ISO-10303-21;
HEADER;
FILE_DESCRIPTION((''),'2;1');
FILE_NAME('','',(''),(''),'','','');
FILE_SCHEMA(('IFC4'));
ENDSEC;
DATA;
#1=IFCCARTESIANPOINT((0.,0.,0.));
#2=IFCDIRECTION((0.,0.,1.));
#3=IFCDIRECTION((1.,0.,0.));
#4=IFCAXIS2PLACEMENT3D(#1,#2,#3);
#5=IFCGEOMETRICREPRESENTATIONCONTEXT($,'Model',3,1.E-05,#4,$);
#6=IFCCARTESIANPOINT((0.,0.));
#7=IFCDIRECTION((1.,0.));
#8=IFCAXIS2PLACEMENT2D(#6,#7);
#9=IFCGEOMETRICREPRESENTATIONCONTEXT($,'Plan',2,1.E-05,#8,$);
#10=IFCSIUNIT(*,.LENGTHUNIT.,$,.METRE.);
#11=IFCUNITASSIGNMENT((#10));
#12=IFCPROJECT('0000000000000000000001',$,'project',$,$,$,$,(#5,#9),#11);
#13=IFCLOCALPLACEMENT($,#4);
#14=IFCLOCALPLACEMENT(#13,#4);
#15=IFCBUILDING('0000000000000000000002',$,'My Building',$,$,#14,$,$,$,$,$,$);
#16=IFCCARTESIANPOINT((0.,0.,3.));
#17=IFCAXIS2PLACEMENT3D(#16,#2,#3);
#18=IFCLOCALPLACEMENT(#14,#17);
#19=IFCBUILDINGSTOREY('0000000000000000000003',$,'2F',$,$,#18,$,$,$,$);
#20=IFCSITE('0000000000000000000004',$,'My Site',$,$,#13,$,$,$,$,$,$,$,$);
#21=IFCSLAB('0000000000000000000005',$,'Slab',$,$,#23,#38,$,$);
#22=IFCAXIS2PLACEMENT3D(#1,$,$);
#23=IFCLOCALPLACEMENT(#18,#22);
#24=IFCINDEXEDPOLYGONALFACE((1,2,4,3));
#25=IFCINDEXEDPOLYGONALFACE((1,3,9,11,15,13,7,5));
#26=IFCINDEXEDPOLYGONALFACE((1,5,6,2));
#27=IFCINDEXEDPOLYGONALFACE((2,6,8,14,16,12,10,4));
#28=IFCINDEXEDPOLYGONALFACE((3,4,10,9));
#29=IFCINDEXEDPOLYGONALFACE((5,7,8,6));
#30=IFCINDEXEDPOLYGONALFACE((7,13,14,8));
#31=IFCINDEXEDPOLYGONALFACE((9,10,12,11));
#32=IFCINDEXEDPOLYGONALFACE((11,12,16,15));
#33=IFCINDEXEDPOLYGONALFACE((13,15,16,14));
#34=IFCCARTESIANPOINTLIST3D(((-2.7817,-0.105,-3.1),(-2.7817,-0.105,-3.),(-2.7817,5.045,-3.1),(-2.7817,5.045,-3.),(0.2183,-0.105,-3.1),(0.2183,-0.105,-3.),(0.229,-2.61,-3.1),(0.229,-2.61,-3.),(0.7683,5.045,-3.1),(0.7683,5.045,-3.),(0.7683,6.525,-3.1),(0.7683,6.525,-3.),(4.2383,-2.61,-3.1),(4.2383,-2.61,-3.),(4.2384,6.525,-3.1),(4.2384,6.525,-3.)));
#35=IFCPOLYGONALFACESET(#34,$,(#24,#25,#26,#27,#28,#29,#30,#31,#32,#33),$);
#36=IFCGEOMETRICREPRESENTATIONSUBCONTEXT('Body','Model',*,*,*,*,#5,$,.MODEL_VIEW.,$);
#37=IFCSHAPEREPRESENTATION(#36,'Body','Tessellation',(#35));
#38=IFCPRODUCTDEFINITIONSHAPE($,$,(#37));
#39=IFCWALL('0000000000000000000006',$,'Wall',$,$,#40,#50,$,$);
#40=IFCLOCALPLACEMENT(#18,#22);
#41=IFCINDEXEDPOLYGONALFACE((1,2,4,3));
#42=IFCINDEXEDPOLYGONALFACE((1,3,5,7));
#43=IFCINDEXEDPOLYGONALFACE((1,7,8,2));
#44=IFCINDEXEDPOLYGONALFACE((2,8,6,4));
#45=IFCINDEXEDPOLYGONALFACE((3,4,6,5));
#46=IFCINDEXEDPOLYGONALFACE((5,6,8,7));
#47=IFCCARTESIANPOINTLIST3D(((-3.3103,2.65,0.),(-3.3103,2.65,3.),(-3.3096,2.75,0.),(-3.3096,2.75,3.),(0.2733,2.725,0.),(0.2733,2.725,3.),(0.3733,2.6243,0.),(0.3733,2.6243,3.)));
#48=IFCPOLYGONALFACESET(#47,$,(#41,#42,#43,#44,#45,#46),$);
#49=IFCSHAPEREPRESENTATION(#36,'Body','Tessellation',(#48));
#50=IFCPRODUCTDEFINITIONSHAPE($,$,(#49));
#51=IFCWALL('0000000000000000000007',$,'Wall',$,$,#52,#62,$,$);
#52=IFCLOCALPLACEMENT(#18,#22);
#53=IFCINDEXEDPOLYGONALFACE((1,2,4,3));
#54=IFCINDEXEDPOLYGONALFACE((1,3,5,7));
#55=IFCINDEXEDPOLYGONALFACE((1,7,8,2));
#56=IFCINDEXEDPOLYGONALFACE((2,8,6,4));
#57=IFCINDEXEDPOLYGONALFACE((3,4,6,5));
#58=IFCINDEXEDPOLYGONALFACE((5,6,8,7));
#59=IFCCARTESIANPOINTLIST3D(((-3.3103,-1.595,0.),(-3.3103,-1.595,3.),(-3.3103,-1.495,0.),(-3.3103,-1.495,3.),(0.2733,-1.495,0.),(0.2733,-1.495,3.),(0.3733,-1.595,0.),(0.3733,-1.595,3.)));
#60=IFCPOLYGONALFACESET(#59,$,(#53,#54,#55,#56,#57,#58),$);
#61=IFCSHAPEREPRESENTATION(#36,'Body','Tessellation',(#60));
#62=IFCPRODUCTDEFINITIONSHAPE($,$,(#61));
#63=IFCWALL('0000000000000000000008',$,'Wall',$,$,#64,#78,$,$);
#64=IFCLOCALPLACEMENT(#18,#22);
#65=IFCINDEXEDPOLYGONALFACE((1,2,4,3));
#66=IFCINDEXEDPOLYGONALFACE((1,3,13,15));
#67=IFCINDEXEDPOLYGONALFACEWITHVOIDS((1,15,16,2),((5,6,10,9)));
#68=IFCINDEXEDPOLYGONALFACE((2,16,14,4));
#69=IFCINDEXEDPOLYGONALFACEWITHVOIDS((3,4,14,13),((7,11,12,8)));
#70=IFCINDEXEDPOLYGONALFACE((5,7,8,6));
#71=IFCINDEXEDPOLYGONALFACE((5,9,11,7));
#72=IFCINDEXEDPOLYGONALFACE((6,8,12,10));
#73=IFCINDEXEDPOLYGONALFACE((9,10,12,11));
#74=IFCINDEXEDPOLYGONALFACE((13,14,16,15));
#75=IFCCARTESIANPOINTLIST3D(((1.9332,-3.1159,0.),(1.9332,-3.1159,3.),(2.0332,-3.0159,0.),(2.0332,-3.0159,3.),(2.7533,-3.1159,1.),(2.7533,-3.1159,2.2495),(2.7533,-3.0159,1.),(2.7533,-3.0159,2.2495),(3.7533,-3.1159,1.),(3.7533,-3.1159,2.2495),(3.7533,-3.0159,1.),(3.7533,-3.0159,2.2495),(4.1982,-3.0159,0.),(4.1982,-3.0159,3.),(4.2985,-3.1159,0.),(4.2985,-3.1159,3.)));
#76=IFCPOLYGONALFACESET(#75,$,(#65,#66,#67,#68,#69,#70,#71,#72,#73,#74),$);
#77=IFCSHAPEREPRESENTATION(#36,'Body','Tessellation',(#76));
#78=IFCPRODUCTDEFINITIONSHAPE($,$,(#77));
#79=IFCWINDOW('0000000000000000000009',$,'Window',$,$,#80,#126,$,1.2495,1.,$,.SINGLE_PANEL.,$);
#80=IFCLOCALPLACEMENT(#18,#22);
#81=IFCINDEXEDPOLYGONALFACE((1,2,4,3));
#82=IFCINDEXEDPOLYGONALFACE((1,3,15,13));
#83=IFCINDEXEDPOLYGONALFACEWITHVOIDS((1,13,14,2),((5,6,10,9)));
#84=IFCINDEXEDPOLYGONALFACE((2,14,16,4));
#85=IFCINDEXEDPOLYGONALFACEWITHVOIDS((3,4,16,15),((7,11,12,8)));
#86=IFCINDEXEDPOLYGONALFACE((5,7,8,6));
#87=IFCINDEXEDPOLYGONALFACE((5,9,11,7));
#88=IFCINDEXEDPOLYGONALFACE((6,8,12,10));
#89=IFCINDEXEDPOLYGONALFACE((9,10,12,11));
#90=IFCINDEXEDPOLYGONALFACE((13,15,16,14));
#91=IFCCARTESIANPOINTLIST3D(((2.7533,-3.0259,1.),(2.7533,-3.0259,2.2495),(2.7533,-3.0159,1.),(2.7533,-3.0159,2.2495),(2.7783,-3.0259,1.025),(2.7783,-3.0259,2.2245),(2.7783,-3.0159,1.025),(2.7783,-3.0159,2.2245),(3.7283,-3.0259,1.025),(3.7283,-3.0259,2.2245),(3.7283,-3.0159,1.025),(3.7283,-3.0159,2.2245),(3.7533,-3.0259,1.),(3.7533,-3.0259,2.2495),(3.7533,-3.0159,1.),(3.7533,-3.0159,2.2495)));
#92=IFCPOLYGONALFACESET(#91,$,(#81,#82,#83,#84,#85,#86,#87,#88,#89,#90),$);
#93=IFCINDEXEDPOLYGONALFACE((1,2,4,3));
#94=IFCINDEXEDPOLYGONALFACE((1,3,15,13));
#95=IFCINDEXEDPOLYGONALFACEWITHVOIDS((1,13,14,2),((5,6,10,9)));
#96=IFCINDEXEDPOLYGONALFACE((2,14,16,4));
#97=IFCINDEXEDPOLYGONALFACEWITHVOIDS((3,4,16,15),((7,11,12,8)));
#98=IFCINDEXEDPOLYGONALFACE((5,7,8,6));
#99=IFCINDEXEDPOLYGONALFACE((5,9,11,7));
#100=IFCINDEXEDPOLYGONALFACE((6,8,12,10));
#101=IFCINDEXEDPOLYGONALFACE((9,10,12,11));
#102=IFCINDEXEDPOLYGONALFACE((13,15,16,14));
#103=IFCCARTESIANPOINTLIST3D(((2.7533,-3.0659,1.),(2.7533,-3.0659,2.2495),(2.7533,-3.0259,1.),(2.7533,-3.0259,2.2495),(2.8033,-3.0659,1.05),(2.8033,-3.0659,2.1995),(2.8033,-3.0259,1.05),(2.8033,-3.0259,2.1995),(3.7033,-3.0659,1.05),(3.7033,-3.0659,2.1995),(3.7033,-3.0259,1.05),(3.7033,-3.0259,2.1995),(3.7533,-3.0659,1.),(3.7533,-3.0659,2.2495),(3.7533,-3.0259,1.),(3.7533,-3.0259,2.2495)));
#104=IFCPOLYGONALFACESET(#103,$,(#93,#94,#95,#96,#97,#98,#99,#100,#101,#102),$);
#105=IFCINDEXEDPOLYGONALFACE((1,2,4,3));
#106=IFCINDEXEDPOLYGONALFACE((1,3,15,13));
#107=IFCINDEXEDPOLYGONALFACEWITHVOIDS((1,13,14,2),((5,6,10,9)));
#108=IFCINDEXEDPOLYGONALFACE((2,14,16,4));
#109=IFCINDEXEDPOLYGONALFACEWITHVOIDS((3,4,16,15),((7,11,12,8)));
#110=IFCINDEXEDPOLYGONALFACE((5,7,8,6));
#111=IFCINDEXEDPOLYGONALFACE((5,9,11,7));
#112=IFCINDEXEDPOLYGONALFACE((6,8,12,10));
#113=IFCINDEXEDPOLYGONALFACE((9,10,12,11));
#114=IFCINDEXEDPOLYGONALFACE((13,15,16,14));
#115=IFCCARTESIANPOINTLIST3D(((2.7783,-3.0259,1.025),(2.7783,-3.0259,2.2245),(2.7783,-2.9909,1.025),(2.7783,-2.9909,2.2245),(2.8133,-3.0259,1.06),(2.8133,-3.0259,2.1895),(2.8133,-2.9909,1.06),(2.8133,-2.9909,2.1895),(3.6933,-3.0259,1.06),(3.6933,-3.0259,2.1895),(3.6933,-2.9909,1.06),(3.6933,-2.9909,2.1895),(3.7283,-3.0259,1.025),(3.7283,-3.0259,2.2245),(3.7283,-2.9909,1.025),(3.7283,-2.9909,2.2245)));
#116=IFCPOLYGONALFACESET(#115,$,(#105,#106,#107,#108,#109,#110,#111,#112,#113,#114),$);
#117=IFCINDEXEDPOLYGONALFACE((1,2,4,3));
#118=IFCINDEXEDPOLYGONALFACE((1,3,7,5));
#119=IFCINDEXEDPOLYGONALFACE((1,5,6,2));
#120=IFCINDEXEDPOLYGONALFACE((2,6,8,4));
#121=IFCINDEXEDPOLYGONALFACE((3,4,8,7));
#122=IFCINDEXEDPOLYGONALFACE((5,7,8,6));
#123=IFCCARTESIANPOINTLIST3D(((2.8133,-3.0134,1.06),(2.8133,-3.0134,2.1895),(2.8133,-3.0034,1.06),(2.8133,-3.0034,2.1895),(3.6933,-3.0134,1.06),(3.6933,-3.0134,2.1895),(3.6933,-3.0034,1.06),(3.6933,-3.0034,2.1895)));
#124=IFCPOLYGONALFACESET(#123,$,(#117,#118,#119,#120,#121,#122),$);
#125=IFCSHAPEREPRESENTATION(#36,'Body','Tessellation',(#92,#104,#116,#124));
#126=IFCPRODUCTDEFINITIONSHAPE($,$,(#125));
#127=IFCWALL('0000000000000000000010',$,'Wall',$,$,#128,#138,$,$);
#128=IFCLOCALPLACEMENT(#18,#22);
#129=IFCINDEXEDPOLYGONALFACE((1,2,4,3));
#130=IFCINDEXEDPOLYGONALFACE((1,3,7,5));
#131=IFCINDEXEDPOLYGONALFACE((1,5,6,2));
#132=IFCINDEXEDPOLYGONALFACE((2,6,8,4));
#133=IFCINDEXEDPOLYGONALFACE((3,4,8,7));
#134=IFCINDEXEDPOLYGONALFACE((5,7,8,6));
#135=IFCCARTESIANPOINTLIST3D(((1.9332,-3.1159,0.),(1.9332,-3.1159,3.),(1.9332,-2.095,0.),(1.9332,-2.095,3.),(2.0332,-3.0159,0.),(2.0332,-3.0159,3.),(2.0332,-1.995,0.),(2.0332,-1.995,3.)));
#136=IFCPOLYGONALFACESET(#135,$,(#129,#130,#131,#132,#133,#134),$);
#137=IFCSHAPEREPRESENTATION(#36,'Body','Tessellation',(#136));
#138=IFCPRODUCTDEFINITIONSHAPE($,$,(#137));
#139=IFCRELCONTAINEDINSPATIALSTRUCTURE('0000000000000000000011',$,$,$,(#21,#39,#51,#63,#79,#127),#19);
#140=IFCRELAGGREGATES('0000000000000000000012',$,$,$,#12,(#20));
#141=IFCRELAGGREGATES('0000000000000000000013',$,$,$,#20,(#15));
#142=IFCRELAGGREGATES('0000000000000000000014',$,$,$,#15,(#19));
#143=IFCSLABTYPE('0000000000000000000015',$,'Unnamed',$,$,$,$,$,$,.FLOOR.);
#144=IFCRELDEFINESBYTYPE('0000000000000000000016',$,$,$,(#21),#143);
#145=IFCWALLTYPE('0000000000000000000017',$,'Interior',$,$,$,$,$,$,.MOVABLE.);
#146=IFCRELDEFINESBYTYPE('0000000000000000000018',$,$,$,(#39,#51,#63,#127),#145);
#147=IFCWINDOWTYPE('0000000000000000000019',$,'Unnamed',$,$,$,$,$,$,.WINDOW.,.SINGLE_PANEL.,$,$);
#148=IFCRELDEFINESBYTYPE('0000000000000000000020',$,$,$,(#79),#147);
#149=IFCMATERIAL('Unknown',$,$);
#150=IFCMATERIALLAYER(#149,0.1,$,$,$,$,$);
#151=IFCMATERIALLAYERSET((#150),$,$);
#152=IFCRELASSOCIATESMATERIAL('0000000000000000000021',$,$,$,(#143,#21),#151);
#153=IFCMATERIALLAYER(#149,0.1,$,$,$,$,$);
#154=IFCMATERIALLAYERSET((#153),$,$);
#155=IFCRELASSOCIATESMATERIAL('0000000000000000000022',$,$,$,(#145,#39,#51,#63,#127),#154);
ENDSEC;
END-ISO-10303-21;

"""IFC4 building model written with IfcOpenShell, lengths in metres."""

from ifc_helpers import new_model, entity, si_unit, frame, origin_with_axes, origin_2d_with_axis, place, context, subcontext, project, spatial, line, indexed_curve, outline, extrude, shape, source, transform, mapped, material, layer, layer_set, layer_usage, type_object, type_shapes, element, fill, save


model = new_model("IFC4")

# Units and contexts
model_context = context("Model", 3, precision=1e-05, world=origin_with_axes())
plan_context = context("Plan", 2, precision=1e-05, world=origin_2d_with_axis())
body_context_1 = subcontext(model_context, "Body", "Model", "MODEL_VIEW")
body_context_2 = subcontext(plan_context, "Body", "Plan", "PLAN_VIEW")
ifc_project = project(units=[si_unit("LENGTHUNIT", "METRE")], contexts=[model_context, plan_context])

# Site, building, storey
site_placement = place(None, origin_with_axes())
site = spatial("IfcSite", under=ifc_project, at=site_placement, Name="My Site")
building_placement = place(site_placement, origin_with_axes())
building = spatial("IfcBuilding", under=site, at=building_placement, Name="My Building")
storey_placement = place(building_placement, frame((0.0, 0.0, 3.0), z_axis=(0.0, 0.0, 1.0), x_axis=(1.0, 0.0, 0.0)))
storey = spatial("IfcBuildingStorey", under=building, at=storey_placement, Name="2F")

# Slab
ifc_material = material(Name="Unknown")
ifc_layer_1 = layer(ifc_material, 0.1)
ifc_layer_set_1 = layer_set([ifc_layer_1])
ifc_layer_usage_1 = layer_usage(ifc_layer_set_1, "AXIS3", "POSITIVE", -0.1)
slab_type = type_object("IfcSlabType", Name="Unnamed", PredefinedType="FLOOR", material=ifc_layer_set_1)
slab_placement = place(storey_placement, frame((4.2383, -2.61, -3.0), z_axis=(0.0, 0.0, 1.0), x_axis=(1.0, 0.0, 0.0)))
element("IfcSlab", 1, at=slab_placement, inside=storey, type_object=slab_type, material=ifc_layer_usage_1, Name="Slab", context=body_context_1, shape_type="SweptSolid", body=[
    extrude(outline(indexed_curve([(0.0, 0.0), (0.0, 9.135), (-3.47, 9.135), (-3.47, 7.655), (-7.02, 7.655), (-7.02, 2.505), (-4.02, 2.505), (-4.0094, 0.0), (0.0, 0.0)])), frame((0.0, 0.0, -0.1), z_axis=(0.0, 0.0, 1.0), x_axis=(1.0, 0.0, 0.0)), (0.0, 0.0, 1.0), 0.1),
])

# Walls
ifc_layer_2 = layer(ifc_material, 0.1)
ifc_layer_set_2 = layer_set([ifc_layer_2])
ifc_layer_usage_2 = layer_usage(ifc_layer_set_2, "AXIS2", "POSITIVE", 0.0)
wall_type = type_object("IfcWallType", Name="Interior", PredefinedType="MOVABLE", material=ifc_layer_set_2)
wall_1_placement = place(storey_placement, frame((-3.3103, 2.65, 0.0), z_axis=(0.0, 0.0, 1.0), x_axis=(0.999976, -0.006981, 0.0)))
element("IfcWall", 2, at=wall_1_placement, inside=storey, type_object=wall_type, material=ifc_layer_usage_2, Name="Wall", context=body_context_1, shape_type="SweptSolid", body=[
    extrude(outline(indexed_curve([(0.0, 0.0), (0.0, 0.1), (3.583, 0.1), (3.6837, 0.0)], segments=[line(1, 2, 3, 4, 1)])), origin_with_axes(), (0.0, 0.0, 1.0), 3.0),
])
ifc_layer_usage_3 = layer_usage(ifc_layer_set_2, "AXIS2", "POSITIVE", 0.0)
wall_2_placement = place(storey_placement, frame((-3.3103, -1.595, 0.0), z_axis=(0.0, 0.0, 1.0), x_axis=(1.0, 0.0, 0.0)))
element("IfcWall", 3, at=wall_2_placement, inside=storey, type_object=wall_type, material=ifc_layer_usage_3, Name="Wall", context=body_context_1, shape_type="SweptSolid", body=[
    extrude(outline(indexed_curve([(0.0, 0.0), (0.0, 0.1), (3.5836, 0.1), (3.6836, 0.0)], segments=[line(1, 2, 3, 4, 1)])), origin_with_axes(), (0.0, 0.0, 1.0), 3.0),
])

# Wall, opening, window
ifc_layer_usage_4 = layer_usage(ifc_layer_set_2, "AXIS2", "POSITIVE", 0.0)
wall_3_placement = place(storey_placement, frame((4.1982, -3.0159, 0.0), z_axis=(0.0, 0.0, 1.0), x_axis=(-1.0, 0.0, 0.0)))
wall_3 = element("IfcWall", 4, at=wall_3_placement, inside=storey, type_object=wall_type, material=ifc_layer_usage_4, Name="Wall", context=body_context_1, shape_type="SweptSolid", body=[
    extrude(outline(indexed_curve([(0.0, 0.0), (-0.1004, 0.1), (2.265, 0.1), (2.165, 0.0)], segments=[line(1, 2, 3, 4, 1)])), origin_with_axes(), (0.0, 0.0, 1.0), 3.0),
])
shared_shape_1 = source(origin_with_axes(), body_context_1, "Body", "SweptSolid", [
    extrude(outline(indexed_curve([(0.0, 0.0), (1.0, 0.0), (1.0, 1.2495), (0.0, 1.2495)], segments=[line(1, 2, 3, 4, 1)])), frame((0.0, -0.6, 0.0), z_axis=(0.0, -1.0, 0.0), x_axis=(1.0, 0.0, 0.0)), (0.0, 0.0, -1.0), 1.2),
])
opening_1_placement = place(wall_3_placement, frame((1.4449, 0.1, 1.0), z_axis=(0.0, 0.0, 1.0), x_axis=(-1.0, 0.0, 0.0)))
opening_1 = element("IfcOpeningElement", 5, at=opening_1_placement, cuts=wall_3, PredefinedType="OPENING", context=body_context_1, shape_type="MappedRepresentation", body=[
    mapped(shared_shape_1, transform((0.0, 0.0, 0.0), x_axis=(1.0, 0.0, 0.0), y_axis=(0.0, 1.0, 0.0), z_axis=(0.0, 0.0, 1.0), scale=1.0)),
])
window_type = type_object("IfcWindowType", Name="Unnamed", PartitioningType="SINGLE_PANEL", PredefinedType="WINDOW")
shared_shape_2 = source(origin_with_axes(), body_context_1, "Body", "SweptSolid", [
    extrude(outline(indexed_curve([(0.0, 0.0), (1.0, 0.0), (1.0, 1.2495), (0.0, 1.2495)], segments=[line(1, 2, 3, 4, 1)]), holes=[indexed_curve([(0.025, 0.025), (0.975, 0.025), (0.975, 1.2245), (0.025, 1.2245)], segments=[line(1, 2, 3, 4, 1)])]), frame((0.0, 0.09, 0.0), z_axis=(0.0, -1.0, 0.0), x_axis=(1.0, 0.0, 0.0)), (0.0, 0.0, -1.0), 0.01),
    extrude(outline(indexed_curve([(0.0, 0.0), (1.0, 0.0), (1.0, 1.2495), (0.0, 1.2495)], segments=[line(1, 2, 3, 4, 1)]), holes=[indexed_curve([(0.05, 0.05), (0.95, 0.05), (0.95, 1.1995), (0.05, 1.1995)], segments=[line(1, 2, 3, 4, 1)])]), frame((0.0, 0.05, 0.0), z_axis=(0.0, -1.0, 0.0), x_axis=(1.0, 0.0, 0.0)), (0.0, 0.0, -1.0), 0.04),
    extrude(outline(indexed_curve([(0.0, 0.0), (0.95, 0.0), (0.95, 1.1995), (0.0, 1.1995)], segments=[line(1, 2, 3, 4, 1)]), holes=[indexed_curve([(0.035, 0.035), (0.915, 0.035), (0.915, 1.1645), (0.035, 1.1645)], segments=[line(1, 2, 3, 4, 1)])]), frame((0.025, 0.09, 0.025), z_axis=(0.0, -1.0, 0.0), x_axis=(1.0, 0.0, 0.0)), (0.0, 0.0, -1.0), 0.035),
    extrude(outline(indexed_curve([(0.035, 0.035), (0.915, 0.035), (0.915, 1.1645), (0.035, 1.1645)], segments=[line(1, 2, 3, 4, 1)])), frame((0.025, 0.1025, 0.025), z_axis=(0.0, -1.0, 0.0), x_axis=(1.0, 0.0, 0.0)), (0.0, 0.0, -1.0), 0.01),
])
shared_shape_3 = source(origin_with_axes(), body_context_2, "Body", "Curve2D", [
    entity("IfcIndexedPolyCurve", entity("IfcCartesianPointList2D", [[0.05, 0.05], [0.95, 0.05]])),
    entity("IfcIndexedPolyCurve", entity("IfcCartesianPointList2D", [[0.0, 0.1], [0.025, 0.1], [0.025, 0.09], [0.05, 0.09], [0.05, 0.05], [0.0, 0.05]]), [entity("IfcLineIndex", [1, 2, 3, 4, 5, 6, 1])]),
    entity("IfcIndexedPolyCurve", entity("IfcCartesianPointList2D", [[1.0, 0.1], [0.975, 0.1], [0.975, 0.09], [0.95, 0.09], [0.95, 0.05], [1.0, 0.05]]), [entity("IfcLineIndex", [1, 2, 3, 4, 5, 6, 1])]),
    entity("IfcIndexedPolyCurve", entity("IfcCartesianPointList2D", [[0.025, 0.09], [0.06, 0.09], [0.06, 0.125], [0.025, 0.125]]), [entity("IfcLineIndex", [1, 2, 3, 4, 1])]),
    entity("IfcIndexedPolyCurve", entity("IfcCartesianPointList2D", [[0.975, 0.09], [0.94, 0.09], [0.94, 0.125], [0.975, 0.125]]), [entity("IfcLineIndex", [1, 2, 3, 4, 1])]),
    entity("IfcIndexedPolyCurve", entity("IfcCartesianPointList2D", [[0.06, 0.09], [0.94, 0.09]])),
    entity("IfcIndexedPolyCurve", entity("IfcCartesianPointList2D", [[0.06, 0.125], [0.94, 0.125]])),
    entity("IfcIndexedPolyCurve", entity("IfcCartesianPointList2D", [[0.06, 0.1075], [0.94, 0.1075]])),
])
type_shapes(window_type, [shared_shape_2, shared_shape_3])
window_placement = place(opening_1_placement, frame((0.0, 0.0, 0.0), z_axis=(0.0, 0.0, 1.0), x_axis=(1.0, 0.0, 0.0)))
window = element("IfcWindow", 6, at=window_placement, inside=storey, type_object=window_type, Name="Window", OverallHeight=1.2495, OverallWidth=1.0, PartitioningType="SINGLE_PANEL", shapes=[
    shape(body_context_1, "Body", "MappedRepresentation", [mapped(shared_shape_2, transform((0.0, 0.0, 0.0), x_axis=(1.0, 0.0, 0.0), y_axis=(0.0, 1.0, 0.0), z_axis=(0.0, 0.0, 1.0), scale=1.0))]),
    shape(body_context_2, "Body", "MappedRepresentation", [mapped(shared_shape_3, transform((0.0, 0.0, 0.0), x_axis=(1.0, 0.0, 0.0), y_axis=(0.0, 1.0, 0.0), z_axis=(0.0, 0.0, 1.0), scale=1.0))]),
])
fill(opening_1, window)

# Wall
ifc_layer_usage_5 = layer_usage(ifc_layer_set_2, "AXIS2", "POSITIVE", 0.0)
wall_4_placement = place(storey_placement, frame((2.0332, -3.0159, 0.0), z_axis=(0.0, 0.0, 1.0), x_axis=(0.0, 1.0, 0.0)))
element("IfcWall", 7, at=wall_4_placement, inside=storey, type_object=wall_type, material=ifc_layer_usage_5, Name="Wall", context=body_context_1, shape_type="SweptSolid", body=[
    extrude(outline(indexed_curve([(0.0, 0.0), (-0.1, 0.1), (0.9209, 0.1), (1.0209, 0.0)], segments=[line(1, 2, 3, 4, 1)])), origin_with_axes(), (0.0, 0.0, 1.0), 3.0),
])

save(model, "model.ifc")
